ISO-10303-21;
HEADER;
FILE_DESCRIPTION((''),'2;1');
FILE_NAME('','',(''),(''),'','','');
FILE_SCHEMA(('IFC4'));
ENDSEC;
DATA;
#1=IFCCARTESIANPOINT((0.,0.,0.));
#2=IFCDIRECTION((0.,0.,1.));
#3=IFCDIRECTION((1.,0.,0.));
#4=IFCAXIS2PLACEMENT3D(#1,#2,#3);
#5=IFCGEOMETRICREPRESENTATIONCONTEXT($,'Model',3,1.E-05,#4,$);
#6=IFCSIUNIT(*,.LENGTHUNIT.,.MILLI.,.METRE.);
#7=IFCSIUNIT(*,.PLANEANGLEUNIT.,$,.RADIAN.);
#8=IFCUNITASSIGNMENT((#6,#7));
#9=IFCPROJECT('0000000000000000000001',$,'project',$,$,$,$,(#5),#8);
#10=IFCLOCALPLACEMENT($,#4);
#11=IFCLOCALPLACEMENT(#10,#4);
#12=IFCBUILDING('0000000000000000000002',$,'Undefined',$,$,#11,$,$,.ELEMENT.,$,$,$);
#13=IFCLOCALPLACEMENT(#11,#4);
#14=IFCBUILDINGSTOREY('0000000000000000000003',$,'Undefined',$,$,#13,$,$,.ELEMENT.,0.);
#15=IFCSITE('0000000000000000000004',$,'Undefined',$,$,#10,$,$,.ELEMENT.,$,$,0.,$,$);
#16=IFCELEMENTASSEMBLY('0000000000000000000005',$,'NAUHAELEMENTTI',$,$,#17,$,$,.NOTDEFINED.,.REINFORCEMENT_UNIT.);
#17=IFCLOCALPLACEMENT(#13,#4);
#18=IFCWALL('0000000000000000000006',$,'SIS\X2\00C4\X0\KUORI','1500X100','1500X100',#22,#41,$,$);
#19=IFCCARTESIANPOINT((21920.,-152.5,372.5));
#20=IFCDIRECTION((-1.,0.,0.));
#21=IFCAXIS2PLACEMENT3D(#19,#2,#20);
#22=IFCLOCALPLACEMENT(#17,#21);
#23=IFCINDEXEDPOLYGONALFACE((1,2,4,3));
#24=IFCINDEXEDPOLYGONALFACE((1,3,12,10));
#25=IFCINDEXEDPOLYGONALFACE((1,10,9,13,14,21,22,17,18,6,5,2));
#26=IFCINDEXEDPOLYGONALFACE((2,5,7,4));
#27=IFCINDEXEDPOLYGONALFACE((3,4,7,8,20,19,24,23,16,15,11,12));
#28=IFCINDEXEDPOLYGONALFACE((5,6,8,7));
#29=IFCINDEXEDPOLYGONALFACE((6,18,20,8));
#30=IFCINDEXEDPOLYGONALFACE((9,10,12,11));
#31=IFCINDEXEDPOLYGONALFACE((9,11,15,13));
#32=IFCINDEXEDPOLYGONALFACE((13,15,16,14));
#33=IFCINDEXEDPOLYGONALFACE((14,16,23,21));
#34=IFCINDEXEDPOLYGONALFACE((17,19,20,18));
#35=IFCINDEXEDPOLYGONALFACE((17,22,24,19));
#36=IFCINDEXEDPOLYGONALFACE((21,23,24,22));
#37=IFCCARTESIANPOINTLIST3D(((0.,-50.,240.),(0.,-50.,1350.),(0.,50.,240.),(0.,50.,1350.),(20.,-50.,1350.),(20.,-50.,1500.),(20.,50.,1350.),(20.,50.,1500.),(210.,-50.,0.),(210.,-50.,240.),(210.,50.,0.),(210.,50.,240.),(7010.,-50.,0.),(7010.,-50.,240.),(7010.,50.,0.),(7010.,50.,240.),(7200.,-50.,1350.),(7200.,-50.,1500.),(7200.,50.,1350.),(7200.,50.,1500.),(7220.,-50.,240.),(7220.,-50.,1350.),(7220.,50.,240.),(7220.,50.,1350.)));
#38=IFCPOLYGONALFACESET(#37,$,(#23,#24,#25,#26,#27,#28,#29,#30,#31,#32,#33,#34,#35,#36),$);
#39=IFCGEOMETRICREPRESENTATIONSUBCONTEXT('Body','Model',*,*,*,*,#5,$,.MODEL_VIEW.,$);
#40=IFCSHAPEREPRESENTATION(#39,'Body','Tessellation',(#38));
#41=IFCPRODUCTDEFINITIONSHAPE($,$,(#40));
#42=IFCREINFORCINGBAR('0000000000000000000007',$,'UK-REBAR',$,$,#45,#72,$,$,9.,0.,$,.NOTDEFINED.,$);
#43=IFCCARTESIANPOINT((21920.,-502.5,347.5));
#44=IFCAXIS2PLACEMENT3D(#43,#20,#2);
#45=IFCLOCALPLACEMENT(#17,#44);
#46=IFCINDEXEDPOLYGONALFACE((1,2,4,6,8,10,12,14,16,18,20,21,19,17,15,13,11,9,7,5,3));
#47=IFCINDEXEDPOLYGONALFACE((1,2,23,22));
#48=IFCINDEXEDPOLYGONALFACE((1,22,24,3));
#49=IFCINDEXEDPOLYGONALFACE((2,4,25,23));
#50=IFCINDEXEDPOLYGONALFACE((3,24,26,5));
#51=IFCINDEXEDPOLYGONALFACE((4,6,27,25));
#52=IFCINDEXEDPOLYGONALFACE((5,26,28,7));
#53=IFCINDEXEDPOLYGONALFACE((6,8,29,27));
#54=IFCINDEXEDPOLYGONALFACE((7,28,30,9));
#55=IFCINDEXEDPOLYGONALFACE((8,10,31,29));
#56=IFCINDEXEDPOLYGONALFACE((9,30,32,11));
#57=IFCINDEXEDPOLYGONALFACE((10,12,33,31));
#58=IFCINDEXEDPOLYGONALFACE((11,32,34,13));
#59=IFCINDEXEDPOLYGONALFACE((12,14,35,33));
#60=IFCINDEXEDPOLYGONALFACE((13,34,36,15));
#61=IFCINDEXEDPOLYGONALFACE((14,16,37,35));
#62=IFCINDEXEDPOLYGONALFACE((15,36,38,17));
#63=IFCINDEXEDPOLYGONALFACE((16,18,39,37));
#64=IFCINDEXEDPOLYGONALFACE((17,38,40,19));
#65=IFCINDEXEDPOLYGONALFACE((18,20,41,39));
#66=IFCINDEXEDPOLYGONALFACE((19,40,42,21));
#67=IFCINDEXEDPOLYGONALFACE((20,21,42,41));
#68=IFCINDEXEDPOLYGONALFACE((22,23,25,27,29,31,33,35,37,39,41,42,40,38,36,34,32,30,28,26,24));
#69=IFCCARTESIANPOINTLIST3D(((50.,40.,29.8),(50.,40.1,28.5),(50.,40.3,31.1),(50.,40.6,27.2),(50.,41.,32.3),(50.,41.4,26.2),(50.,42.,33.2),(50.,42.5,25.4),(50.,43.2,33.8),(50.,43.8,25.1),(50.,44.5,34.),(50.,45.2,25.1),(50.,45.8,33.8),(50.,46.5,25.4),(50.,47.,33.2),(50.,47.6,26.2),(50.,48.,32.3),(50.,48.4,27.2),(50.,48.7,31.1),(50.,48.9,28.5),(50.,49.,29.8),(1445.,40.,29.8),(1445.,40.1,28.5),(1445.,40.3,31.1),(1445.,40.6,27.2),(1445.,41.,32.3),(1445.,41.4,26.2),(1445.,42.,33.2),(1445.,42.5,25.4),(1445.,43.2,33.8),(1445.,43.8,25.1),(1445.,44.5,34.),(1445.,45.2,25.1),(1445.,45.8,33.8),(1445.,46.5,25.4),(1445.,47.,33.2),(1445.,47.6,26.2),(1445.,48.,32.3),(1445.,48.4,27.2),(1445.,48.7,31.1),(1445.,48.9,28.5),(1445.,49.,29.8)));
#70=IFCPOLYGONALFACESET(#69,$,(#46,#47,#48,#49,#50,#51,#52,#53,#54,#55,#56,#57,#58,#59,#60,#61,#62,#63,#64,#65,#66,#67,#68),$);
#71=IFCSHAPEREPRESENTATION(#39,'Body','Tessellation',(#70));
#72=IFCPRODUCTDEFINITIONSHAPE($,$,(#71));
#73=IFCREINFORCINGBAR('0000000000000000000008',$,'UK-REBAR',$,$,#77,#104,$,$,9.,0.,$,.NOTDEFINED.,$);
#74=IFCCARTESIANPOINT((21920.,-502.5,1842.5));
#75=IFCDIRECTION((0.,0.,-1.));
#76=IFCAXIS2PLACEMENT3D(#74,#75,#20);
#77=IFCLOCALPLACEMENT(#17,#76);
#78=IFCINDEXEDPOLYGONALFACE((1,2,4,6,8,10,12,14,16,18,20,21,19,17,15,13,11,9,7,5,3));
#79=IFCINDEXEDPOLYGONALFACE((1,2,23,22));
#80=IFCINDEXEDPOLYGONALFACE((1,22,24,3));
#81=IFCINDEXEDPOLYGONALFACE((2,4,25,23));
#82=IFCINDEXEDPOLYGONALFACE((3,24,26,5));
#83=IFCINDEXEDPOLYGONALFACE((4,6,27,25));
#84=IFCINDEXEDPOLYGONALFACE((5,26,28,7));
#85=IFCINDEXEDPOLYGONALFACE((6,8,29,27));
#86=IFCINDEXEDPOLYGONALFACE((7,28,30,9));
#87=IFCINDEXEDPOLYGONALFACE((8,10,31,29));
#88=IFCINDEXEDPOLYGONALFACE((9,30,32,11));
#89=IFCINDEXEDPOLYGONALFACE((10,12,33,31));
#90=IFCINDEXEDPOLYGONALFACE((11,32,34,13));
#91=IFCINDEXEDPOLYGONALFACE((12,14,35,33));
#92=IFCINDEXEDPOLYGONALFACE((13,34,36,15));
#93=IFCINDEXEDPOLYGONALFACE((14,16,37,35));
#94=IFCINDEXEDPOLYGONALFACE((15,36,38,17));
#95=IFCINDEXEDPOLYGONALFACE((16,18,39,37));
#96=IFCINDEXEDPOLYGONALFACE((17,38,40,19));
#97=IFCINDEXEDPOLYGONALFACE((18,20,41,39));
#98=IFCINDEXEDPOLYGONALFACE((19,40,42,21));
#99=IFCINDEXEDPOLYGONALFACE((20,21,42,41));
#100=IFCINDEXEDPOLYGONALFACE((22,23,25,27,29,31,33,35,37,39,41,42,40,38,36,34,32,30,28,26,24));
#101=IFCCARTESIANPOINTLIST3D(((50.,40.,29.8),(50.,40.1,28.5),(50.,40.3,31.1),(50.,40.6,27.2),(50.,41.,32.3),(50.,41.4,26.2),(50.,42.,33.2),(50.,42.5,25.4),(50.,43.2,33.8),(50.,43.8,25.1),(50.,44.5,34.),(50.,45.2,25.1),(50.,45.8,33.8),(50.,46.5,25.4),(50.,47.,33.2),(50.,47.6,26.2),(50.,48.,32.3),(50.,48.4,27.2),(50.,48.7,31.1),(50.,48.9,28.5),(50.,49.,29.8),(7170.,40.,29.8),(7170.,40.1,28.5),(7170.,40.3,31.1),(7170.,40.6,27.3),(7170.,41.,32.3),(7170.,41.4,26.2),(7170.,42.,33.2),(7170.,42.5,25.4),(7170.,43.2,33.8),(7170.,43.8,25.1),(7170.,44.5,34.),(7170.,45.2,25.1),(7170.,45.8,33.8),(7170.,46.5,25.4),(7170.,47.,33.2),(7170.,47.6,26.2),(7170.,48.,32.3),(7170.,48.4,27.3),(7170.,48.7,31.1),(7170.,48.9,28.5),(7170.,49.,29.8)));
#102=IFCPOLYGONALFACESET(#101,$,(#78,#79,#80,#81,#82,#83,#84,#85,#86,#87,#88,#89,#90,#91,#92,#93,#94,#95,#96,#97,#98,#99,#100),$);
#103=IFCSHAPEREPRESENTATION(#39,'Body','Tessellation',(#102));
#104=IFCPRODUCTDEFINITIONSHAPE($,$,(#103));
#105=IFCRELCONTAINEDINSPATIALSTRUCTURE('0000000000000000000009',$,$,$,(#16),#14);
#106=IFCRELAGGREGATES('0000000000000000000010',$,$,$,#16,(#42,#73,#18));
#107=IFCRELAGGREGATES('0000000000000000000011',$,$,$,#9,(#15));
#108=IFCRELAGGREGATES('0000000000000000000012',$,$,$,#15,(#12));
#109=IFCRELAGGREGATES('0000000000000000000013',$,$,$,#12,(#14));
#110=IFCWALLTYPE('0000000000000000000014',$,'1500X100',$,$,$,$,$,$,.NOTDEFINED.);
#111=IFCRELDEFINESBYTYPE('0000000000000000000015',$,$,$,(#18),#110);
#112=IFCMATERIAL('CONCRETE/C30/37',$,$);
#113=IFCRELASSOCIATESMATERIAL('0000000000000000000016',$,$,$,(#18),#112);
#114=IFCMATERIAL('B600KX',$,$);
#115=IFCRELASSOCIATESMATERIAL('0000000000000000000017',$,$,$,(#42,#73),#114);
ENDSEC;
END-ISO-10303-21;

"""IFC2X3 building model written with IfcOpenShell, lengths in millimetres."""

from ifc_helpers import new_model, entity, si_unit, frame, frame_2d, origin_with_axes, origin_2d_with_axis, place, context, subcontext, project, spatial, rectangle, extrude, boolean, source, transform, mapped, material, type_object, element, aggregate, save


model = new_model("IFC2X3")

# Units and contexts
model_context = context("Model", 3, precision=1e-05, world=origin_with_axes())
body_context = subcontext(model_context, "Body", "Model", "MODEL_VIEW")
ifc_project = project(units=[si_unit("LENGTHUNIT", "METRE", prefix="MILLI"), si_unit("PLANEANGLEUNIT", "RADIAN")], contexts=[model_context])

# Site, building, storey
site_placement = place(None, origin_with_axes())
site = spatial("IfcSite", under=ifc_project, at=site_placement, Name="Undefined", CompositionType="ELEMENT", RefElevation=0.0)
building_placement = place(site_placement, origin_with_axes())
building = spatial("IfcBuilding", under=site, at=building_placement, Name="Undefined", CompositionType="ELEMENT")
storey_placement = place(building_placement, origin_with_axes())
storey = spatial("IfcBuildingStorey", under=building, at=storey_placement, Name="Undefined", CompositionType="ELEMENT", Elevation=0.0)

# Element assembly
assembly_1_placement = place(storey_placement, origin_with_axes())
assembly_1 = element("IfcElementAssembly", 1, at=assembly_1_placement, inside=storey, Name="NAUHAELEMENTTI", AssemblyPlace="NOTDEFINED", PredefinedType="REINFORCEMENT_UNIT")
ifc_material_1 = material(Name="CONCRETE/C30/37")

# Wall
wall_type_1 = type_object("IfcWallType", Name="1500X100", PredefinedType="NOTDEFINED")
wall_1_placement = place(assembly_1_placement, frame((21920.0, -152.5, 372.5), z_axis=(0.0, 0.0, 1.0), x_axis=(-1.0, 0.0, 0.0)))
wall_1 = element("IfcWall", 2, at=wall_1_placement, type_object=wall_type_1, material=ifc_material_1, Name="SISÄKUORI", Description="1500X100", ObjectType="1500X100", context=body_context, shape_type="CSG", body=[
    boolean("DIFFERENCE", boolean("DIFFERENCE", boolean("DIFFERENCE", boolean("DIFFERENCE", extrude(rectangle(XDim=7220.0, YDim=100.0, at=frame_2d((0.0, 3610.0), x_axis=(0.0, -1.0))), frame((0.0, 0.0, 0.0), z_axis=(0.0, 0.0, 1.0), x_axis=(0.0, -1.0, 0.0)), (0.0, 0.0, 1.0), 1500.0), extrude(rectangle(XDim=20.0, YDim=150.0, at=origin_2d_with_axis()), frame((7210.0, 150.0, 1425.0), z_axis=(0.0, -1.0, 0.0), x_axis=(1.0, 0.0, 0.0)), (0.0, 0.0, 1.0), 300.0)), extrude(rectangle(XDim=20.0, YDim=150.0, at=origin_2d_with_axis()), frame((10.0, 150.0, 1425.0), z_axis=(0.0, -1.0, 0.0), x_axis=(1.0, 0.0, 0.0)), (0.0, 0.0, 1.0), 300.0)), extrude(rectangle(XDim=210.0, YDim=240.0, at=origin_2d_with_axis()), frame((7115.0, 350.0, 120.0), z_axis=(0.0, -1.0, 0.0), x_axis=(1.0, 0.0, 0.0)), (0.0, 0.0, 1.0), 500.0)), extrude(rectangle(XDim=210.0, YDim=240.0, at=origin_2d_with_axis()), frame((105.0, 350.0, 120.0), z_axis=(0.0, -1.0, 0.0), x_axis=(1.0, 0.0, 0.0)), (0.0, 0.0, 1.0), 500.0)),
])

# Reinforcing bars
ifc_material_2 = material(Name="B600KX")
shared_shape_1 = source(origin_with_axes(), body_context, "Body", "AdvancedSweptSolid", [
    entity("IfcSweptDiskSolid", entity("IfcTrimmedCurve", entity("IfcLine", entity("IfcCartesianPoint", [0.0, 0.0, 0.0]), entity("IfcVector", entity("IfcDirection", [1.0, 0.0, 0.0]), 1.0)), [entity("IfcParameterValue", 0.0)], [entity("IfcParameterValue", 1395.0)], True, "PARAMETER"), 4.5, None, 0.0, 1395.0),
])
reinforcing_bar_1_placement = place(assembly_1_placement, frame((21920.0, -502.5, 347.5), z_axis=(-1.0, 0.0, 0.0), x_axis=(0.0, 0.0, 1.0)))
reinforcing_bar_1 = element("IfcReinforcingBar", 3, at=reinforcing_bar_1_placement, material=ifc_material_2, Name="UK-REBAR", BarRole="NOTDEFINED", CrossSectionArea=0.0, NominalDiameter=9.0, context=body_context, shape_type="MappedRepresentation", body=[
    mapped(shared_shape_1, transform((50.0, 44.5, 29.5))),
])
shared_shape_2 = source(origin_with_axes(), body_context, "Body", "AdvancedSweptSolid", [
    entity("IfcSweptDiskSolid", entity("IfcTrimmedCurve", entity("IfcLine", entity("IfcCartesianPoint", [0.0, 0.0, 0.0]), entity("IfcVector", entity("IfcDirection", [1.0, 0.0, 0.0]), 1.0)), [entity("IfcParameterValue", 0.0)], [entity("IfcParameterValue", 7120.0)], True, "PARAMETER"), 4.5, None, 0.0, 7120.0),
])
reinforcing_bar_2_placement = place(assembly_1_placement, frame((21920.0, -502.5, 1842.5), z_axis=(0.0, 0.0, -1.0), x_axis=(-1.0, 0.0, 0.0)))
reinforcing_bar_2 = element("IfcReinforcingBar", 4, at=reinforcing_bar_2_placement, material=ifc_material_2, Name="UK-REBAR", BarRole="NOTDEFINED", CrossSectionArea=0.0, NominalDiameter=9.0, context=body_context, shape_type="MappedRepresentation", body=[
    mapped(shared_shape_2, transform((50.0, 44.5, 29.5))),
])
aggregate(assembly_1, [reinforcing_bar_1, reinforcing_bar_2, wall_1])

save(model, "model.ifc")
